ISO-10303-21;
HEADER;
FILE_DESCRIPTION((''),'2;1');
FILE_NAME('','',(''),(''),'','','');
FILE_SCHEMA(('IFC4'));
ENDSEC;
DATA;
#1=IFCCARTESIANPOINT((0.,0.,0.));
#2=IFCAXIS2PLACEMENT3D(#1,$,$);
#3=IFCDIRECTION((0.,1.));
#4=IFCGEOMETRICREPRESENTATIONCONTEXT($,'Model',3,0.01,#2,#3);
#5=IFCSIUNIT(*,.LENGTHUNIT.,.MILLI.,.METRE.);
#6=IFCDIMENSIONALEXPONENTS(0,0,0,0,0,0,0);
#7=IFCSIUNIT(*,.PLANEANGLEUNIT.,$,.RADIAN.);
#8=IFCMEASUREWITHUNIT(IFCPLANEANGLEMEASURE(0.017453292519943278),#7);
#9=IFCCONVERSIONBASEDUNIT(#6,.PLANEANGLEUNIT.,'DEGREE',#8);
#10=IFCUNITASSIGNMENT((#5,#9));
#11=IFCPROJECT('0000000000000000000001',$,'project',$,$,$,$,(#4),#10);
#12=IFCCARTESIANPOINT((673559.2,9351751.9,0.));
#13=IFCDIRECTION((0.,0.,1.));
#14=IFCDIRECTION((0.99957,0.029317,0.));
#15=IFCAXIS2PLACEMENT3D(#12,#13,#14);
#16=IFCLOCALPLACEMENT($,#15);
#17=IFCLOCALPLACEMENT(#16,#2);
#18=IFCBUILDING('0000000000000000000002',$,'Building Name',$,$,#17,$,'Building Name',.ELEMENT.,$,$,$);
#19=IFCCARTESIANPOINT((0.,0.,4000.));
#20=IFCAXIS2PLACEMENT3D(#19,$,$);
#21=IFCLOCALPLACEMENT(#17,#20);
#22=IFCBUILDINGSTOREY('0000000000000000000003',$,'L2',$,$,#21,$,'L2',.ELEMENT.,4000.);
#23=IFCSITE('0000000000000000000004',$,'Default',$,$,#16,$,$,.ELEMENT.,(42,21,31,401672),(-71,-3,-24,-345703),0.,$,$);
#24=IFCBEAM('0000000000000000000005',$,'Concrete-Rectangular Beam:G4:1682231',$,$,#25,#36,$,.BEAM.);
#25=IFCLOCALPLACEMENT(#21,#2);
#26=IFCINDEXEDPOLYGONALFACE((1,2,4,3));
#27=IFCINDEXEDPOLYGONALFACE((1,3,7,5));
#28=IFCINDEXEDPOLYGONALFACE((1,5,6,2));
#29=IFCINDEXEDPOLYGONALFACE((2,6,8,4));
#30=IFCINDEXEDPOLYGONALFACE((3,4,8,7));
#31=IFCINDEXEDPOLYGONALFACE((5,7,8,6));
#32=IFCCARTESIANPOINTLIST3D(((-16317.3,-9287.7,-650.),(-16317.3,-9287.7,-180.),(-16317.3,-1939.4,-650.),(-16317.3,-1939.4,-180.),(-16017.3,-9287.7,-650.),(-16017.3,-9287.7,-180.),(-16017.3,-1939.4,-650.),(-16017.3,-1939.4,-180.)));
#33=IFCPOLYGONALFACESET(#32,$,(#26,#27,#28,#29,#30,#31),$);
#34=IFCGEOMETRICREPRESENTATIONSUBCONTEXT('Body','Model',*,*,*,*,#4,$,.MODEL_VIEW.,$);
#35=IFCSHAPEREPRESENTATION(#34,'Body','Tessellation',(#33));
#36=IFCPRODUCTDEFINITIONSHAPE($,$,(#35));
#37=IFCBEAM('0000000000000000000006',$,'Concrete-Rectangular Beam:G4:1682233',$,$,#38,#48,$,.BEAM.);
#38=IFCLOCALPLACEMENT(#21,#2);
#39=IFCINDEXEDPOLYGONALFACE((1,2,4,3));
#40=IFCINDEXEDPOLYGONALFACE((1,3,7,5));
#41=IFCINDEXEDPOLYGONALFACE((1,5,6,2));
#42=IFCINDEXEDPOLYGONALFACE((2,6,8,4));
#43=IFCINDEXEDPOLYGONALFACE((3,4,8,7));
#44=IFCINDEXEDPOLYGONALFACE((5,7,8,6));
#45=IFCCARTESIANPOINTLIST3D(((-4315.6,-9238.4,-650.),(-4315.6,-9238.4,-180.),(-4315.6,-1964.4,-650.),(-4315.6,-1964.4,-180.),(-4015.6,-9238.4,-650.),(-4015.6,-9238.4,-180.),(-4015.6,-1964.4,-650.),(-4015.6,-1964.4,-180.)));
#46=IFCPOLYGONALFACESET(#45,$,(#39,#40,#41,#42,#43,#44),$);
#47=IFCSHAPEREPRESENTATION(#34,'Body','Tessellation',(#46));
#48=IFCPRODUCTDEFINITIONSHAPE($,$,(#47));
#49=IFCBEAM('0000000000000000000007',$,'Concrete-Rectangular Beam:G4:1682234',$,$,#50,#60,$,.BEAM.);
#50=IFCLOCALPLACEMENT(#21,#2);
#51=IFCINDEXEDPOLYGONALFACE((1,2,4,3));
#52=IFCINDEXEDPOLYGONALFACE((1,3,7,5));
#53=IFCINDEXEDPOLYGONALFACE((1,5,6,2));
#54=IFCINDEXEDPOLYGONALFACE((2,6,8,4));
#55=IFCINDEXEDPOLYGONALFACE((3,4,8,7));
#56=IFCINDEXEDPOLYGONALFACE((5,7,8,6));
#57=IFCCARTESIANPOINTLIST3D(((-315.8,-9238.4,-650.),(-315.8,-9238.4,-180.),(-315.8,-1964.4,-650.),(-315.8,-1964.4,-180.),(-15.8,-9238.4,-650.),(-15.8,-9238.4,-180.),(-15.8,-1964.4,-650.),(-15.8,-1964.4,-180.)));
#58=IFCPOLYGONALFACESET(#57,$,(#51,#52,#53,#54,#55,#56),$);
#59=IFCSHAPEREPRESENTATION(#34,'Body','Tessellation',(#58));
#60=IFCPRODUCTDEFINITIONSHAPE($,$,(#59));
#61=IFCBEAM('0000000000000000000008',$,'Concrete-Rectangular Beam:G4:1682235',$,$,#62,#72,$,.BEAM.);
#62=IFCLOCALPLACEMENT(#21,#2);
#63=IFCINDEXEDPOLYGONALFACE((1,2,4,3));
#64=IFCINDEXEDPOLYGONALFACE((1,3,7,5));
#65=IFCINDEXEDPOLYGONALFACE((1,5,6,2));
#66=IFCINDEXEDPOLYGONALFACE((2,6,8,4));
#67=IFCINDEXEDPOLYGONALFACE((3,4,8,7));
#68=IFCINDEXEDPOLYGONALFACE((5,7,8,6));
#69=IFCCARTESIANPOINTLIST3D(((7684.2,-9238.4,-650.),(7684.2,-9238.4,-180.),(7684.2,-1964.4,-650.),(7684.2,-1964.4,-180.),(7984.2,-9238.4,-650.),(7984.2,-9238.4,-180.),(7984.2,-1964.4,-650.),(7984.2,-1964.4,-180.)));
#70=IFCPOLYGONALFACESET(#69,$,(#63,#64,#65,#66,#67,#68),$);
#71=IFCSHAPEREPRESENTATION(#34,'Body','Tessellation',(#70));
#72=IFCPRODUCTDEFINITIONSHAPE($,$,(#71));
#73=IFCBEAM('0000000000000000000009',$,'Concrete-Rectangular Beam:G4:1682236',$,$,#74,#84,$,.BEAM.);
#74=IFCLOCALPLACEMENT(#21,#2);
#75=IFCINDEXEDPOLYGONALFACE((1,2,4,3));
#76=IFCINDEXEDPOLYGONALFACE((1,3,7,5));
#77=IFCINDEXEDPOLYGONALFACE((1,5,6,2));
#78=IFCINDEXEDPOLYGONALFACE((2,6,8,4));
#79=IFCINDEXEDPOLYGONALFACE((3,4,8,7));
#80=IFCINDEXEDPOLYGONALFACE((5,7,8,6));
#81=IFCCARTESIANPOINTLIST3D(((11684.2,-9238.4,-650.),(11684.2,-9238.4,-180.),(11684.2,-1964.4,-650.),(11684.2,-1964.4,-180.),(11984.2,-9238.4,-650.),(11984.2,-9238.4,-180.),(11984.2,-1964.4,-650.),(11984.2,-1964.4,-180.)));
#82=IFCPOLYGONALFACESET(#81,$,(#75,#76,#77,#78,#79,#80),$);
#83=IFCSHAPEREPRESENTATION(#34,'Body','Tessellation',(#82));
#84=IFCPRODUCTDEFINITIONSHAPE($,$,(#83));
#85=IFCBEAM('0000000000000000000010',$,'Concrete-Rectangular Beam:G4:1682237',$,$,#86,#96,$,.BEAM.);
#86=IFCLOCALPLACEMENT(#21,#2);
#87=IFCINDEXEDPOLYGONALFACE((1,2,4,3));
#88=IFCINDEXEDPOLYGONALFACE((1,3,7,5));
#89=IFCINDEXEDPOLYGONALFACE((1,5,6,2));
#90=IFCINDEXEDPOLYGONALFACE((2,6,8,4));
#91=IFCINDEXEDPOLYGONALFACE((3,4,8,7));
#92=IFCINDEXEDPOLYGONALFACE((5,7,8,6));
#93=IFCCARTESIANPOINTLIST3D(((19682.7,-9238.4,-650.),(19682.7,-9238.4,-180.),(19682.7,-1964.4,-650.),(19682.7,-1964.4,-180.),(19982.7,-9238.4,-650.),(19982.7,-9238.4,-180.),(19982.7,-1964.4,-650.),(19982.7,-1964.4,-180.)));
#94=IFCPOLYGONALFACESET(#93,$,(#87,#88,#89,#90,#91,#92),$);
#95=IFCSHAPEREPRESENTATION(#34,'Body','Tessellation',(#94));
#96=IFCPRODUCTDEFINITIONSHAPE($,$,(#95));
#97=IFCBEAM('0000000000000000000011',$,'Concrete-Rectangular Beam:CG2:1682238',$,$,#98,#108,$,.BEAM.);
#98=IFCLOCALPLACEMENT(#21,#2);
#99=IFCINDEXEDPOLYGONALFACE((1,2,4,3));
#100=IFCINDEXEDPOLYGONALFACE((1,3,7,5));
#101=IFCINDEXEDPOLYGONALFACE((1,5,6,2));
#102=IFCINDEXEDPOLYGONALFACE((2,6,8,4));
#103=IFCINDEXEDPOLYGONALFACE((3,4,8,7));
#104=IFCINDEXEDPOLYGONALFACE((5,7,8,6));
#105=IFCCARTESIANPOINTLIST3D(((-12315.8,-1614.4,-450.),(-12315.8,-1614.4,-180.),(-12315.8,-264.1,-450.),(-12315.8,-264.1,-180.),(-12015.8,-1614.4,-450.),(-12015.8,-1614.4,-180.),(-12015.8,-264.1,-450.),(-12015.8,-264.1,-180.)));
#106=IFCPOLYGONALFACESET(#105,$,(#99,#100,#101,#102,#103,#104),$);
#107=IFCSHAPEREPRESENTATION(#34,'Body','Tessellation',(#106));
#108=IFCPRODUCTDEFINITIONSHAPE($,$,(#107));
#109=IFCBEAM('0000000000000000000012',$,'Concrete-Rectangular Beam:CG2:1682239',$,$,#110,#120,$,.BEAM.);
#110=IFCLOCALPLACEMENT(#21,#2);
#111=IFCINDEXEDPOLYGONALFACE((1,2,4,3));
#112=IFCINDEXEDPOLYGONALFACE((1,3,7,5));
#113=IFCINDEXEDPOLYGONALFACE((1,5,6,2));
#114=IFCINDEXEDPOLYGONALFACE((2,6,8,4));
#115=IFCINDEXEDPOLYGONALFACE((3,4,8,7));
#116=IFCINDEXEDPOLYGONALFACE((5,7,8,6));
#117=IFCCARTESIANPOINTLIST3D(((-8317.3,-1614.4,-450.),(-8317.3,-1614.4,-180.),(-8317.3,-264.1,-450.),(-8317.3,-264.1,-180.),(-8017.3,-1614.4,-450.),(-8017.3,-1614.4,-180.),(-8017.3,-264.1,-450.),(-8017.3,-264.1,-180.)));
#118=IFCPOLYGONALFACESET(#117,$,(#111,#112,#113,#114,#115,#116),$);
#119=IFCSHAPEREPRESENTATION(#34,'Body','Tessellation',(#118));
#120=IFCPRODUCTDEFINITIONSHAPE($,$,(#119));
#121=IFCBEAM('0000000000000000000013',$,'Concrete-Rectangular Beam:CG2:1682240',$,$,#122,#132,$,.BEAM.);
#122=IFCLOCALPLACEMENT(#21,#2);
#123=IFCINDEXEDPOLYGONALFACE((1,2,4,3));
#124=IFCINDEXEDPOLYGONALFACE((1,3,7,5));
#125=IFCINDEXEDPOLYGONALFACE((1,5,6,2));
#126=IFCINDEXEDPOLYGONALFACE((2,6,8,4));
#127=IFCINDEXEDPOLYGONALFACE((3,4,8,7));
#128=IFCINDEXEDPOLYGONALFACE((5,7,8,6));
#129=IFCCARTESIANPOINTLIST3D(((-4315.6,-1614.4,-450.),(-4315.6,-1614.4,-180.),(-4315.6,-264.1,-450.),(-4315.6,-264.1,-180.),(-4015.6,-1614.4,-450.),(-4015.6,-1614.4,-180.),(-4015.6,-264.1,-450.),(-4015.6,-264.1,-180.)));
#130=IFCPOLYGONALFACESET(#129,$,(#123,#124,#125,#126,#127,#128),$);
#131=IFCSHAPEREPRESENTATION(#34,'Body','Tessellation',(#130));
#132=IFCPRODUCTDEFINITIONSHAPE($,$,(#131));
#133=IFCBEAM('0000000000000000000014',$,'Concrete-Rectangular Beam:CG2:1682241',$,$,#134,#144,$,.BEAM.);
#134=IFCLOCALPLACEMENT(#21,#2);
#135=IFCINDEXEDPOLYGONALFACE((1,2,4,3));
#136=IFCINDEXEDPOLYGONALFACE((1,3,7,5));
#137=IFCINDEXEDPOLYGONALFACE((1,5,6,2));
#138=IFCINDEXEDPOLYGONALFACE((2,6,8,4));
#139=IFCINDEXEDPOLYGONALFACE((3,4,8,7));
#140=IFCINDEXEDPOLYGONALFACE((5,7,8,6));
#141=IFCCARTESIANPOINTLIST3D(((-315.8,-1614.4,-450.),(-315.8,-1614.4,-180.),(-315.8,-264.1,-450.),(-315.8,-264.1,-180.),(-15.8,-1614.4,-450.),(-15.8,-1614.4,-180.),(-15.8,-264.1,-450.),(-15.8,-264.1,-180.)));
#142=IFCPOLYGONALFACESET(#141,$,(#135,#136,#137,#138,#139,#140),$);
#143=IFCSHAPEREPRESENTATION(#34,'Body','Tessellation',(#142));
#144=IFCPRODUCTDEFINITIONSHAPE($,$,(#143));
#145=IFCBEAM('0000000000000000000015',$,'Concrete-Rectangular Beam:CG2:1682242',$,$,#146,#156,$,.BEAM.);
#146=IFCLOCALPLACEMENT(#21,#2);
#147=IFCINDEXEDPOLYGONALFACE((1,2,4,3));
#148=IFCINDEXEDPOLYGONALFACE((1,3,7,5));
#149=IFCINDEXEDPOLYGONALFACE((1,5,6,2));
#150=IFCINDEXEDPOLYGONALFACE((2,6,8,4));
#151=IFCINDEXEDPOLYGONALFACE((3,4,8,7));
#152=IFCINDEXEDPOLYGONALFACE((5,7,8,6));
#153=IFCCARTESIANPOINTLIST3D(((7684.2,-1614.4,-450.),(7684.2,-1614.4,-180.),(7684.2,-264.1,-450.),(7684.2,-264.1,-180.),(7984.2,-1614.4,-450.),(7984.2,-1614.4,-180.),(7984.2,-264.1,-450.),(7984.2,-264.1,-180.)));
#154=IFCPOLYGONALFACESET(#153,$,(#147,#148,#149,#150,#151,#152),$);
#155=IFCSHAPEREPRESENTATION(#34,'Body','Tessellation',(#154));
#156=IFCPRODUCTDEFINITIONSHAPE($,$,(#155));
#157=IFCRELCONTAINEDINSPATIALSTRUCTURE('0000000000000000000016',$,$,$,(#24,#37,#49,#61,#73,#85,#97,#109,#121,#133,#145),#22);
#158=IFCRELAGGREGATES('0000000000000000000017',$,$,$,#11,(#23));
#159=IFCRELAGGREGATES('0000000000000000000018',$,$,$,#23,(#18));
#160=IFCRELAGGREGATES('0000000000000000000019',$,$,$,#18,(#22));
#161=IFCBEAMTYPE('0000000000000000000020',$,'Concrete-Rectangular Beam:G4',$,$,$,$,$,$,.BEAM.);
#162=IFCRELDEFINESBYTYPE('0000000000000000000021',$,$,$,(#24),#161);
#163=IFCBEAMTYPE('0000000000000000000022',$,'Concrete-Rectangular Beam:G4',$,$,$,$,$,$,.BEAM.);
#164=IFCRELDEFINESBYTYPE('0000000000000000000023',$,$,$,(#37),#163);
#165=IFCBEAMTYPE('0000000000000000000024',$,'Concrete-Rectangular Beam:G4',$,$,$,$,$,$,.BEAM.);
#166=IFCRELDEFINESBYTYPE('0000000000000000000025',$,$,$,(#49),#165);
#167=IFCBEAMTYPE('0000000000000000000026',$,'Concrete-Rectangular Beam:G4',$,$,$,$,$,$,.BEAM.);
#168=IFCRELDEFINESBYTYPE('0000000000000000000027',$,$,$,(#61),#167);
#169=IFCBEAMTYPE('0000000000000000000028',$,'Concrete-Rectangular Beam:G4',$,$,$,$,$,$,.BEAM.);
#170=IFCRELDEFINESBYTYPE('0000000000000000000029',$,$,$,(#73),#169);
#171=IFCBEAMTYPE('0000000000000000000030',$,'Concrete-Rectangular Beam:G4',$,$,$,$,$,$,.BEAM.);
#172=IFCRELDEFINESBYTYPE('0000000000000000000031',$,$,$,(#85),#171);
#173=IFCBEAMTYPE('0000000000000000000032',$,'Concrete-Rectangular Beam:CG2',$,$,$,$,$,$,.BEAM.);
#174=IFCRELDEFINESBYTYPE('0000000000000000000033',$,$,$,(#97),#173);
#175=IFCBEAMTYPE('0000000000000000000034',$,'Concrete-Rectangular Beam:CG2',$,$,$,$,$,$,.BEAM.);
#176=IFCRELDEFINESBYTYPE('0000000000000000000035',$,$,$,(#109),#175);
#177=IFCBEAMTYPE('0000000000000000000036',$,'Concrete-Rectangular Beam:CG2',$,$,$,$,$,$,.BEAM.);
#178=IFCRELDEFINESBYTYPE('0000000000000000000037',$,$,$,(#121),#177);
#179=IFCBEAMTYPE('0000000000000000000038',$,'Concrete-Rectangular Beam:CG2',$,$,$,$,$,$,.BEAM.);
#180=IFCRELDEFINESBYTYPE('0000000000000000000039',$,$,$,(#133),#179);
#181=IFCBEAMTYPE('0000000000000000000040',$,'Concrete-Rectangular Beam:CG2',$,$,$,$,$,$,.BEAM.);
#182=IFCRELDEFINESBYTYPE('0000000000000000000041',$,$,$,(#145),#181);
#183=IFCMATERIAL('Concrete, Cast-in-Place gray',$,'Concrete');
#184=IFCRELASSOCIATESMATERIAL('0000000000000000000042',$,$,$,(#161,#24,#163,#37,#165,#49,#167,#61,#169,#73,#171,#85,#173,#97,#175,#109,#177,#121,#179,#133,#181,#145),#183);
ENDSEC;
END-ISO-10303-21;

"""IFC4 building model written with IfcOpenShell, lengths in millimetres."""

from ifc_helpers import new_model, entity, si_unit, converted_unit, direction, frame, origin, place, context, subcontext, project, spatial, indexed_curve, outline, extrude, source, transform, mapped, material, type_object, type_shapes, element, save


model = new_model("IFC4")

# Units and contexts
model_context = context("Model", 3, precision=0.01, world=origin(), true_north=direction((0.0, 1.0)))
body_context = subcontext(model_context, "Body", "Model", "MODEL_VIEW")
ifc_project = project(units=[si_unit("LENGTHUNIT", "METRE", prefix="MILLI"), converted_unit("PLANEANGLEUNIT", "DEGREE", entity("IfcPlaneAngleMeasure", 0.017453292519943278), si_unit("PLANEANGLEUNIT", "RADIAN"), dimensions=[0, 0, 0, 0, 0, 0, 0])], contexts=[model_context])

# Site, building, storey
site_placement = place(None, frame((673559.2, 9351751.9, 0.0), z_axis=(0.0, 0.0, 1.0), x_axis=(0.99957, 0.029317, 0.0)))
site = spatial("IfcSite", under=ifc_project, at=site_placement, Name="Default", CompositionType="ELEMENT", RefLatitude=(42, 21, 31, 401672), RefLongitude=(-71, -3, -24, -345703), RefElevation=0.0)
building_placement = place(site_placement, origin())
building = spatial("IfcBuilding", under=site, at=building_placement, Name="Building Name", LongName="Building Name", CompositionType="ELEMENT")
storey_placement = place(building_placement, frame((0.0, 0.0, 4000.0)))
storey = spatial("IfcBuildingStorey", under=building, at=storey_placement, Name="L2", LongName="L2", CompositionType="ELEMENT", Elevation=4000.0)

# Beams
ifc_material = material(Name="Concrete, Cast-in-Place gray", Category="Concrete")
beam_type_1 = type_object("IfcBeamType", Name="Concrete-Rectangular Beam:G4", PredefinedType="BEAM", material=ifc_material)
shared_shape_1 = source(origin(), body_context, "Body", "SweptSolid", [
    extrude(outline(indexed_curve([(-150.0, -235.0), (150.0, -235.0), (150.0, 235.0), (-150.0, 235.0), (-150.0, -235.0)], self_intersect=False)), frame((-16167.3, -9287.7, 3585.0), z_axis=(0.0, 1.0, 0.0), x_axis=(-1.0, 0.0, 0.0)), (0.0, 0.0, 1.0), 7348.3),
])
type_shapes(beam_type_1, [shared_shape_1])
beam_1_placement = place(storey_placement, frame((0.0, 0.0, -4000.0)))
element("IfcBeam", 1, at=beam_1_placement, inside=storey, type_object=beam_type_1, material=ifc_material, Name="Concrete-Rectangular Beam:G4:1682231", PredefinedType="BEAM", context=body_context, shape_type="MappedRepresentation", body=[
    mapped(shared_shape_1, transform((0.0, 0.0, 0.0), scale=1.0)),
])
beam_type_2 = type_object("IfcBeamType", Name="Concrete-Rectangular Beam:G4", PredefinedType="BEAM", material=ifc_material)
shared_shape_2 = source(origin(), body_context, "Body", "SweptSolid", [
    extrude(outline(indexed_curve([(-150.0, -235.0), (150.0, -235.0), (150.0, 235.0), (-150.0, 235.0), (-150.0, -235.0)], self_intersect=False)), frame((-4165.6, -9238.4, 3585.0), z_axis=(0.0, 1.0, 0.0), x_axis=(-1.0, 0.0, 0.0)), (0.0, 0.0, 1.0), 7273.9),
])
type_shapes(beam_type_2, [shared_shape_2])
beam_2_placement = place(storey_placement, frame((0.0, 0.0, -4000.0)))
element("IfcBeam", 2, at=beam_2_placement, inside=storey, type_object=beam_type_2, material=ifc_material, Name="Concrete-Rectangular Beam:G4:1682233", PredefinedType="BEAM", context=body_context, shape_type="MappedRepresentation", body=[
    mapped(shared_shape_2, transform((0.0, 0.0, 0.0), scale=1.0)),
])
beam_type_3 = type_object("IfcBeamType", Name="Concrete-Rectangular Beam:G4", PredefinedType="BEAM", material=ifc_material)
shared_shape_3 = source(origin(), body_context, "Body", "SweptSolid", [
    extrude(outline(indexed_curve([(-150.0, -235.0), (150.0, -235.0), (150.0, 235.0), (-150.0, 235.0), (-150.0, -235.0)], self_intersect=False)), frame((-165.8, -9238.4, 3585.0), z_axis=(0.0, 1.0, 0.0), x_axis=(-1.0, 0.0, 0.0)), (0.0, 0.0, 1.0), 7273.9),
])
type_shapes(beam_type_3, [shared_shape_3])
beam_3_placement = place(storey_placement, frame((0.0, 0.0, -4000.0)))
element("IfcBeam", 3, at=beam_3_placement, inside=storey, type_object=beam_type_3, material=ifc_material, Name="Concrete-Rectangular Beam:G4:1682234", PredefinedType="BEAM", context=body_context, shape_type="MappedRepresentation", body=[
    mapped(shared_shape_3, transform((0.0, 0.0, 0.0), scale=1.0)),
])
beam_type_4 = type_object("IfcBeamType", Name="Concrete-Rectangular Beam:G4", PredefinedType="BEAM", material=ifc_material)
shared_shape_4 = source(origin(), body_context, "Body", "SweptSolid", [
    extrude(outline(indexed_curve([(-150.0, -235.0), (150.0, -235.0), (150.0, 235.0), (-150.0, 235.0), (-150.0, -235.0)], self_intersect=False)), frame((7834.2, -9238.4, 3585.0), z_axis=(0.0, 1.0, 0.0), x_axis=(-1.0, 0.0, 0.0)), (0.0, 0.0, 1.0), 7273.9),
])
type_shapes(beam_type_4, [shared_shape_4])
beam_4_placement = place(storey_placement, frame((0.0, 0.0, -4000.0)))
element("IfcBeam", 4, at=beam_4_placement, inside=storey, type_object=beam_type_4, material=ifc_material, Name="Concrete-Rectangular Beam:G4:1682235", PredefinedType="BEAM", context=body_context, shape_type="MappedRepresentation", body=[
    mapped(shared_shape_4, transform((0.0, 0.0, 0.0), scale=1.0)),
])
beam_type_5 = type_object("IfcBeamType", Name="Concrete-Rectangular Beam:G4", PredefinedType="BEAM", material=ifc_material)
shared_shape_5 = source(origin(), body_context, "Body", "SweptSolid", [
    extrude(outline(indexed_curve([(-150.0, -235.0), (150.0, -235.0), (150.0, 235.0), (-150.0, 235.0), (-150.0, -235.0)], self_intersect=False)), frame((11834.2, -9238.4, 3585.0), z_axis=(0.0, 1.0, 0.0), x_axis=(-1.0, 0.0, 0.0)), (0.0, 0.0, 1.0), 7273.9),
])
type_shapes(beam_type_5, [shared_shape_5])
beam_5_placement = place(storey_placement, frame((0.0, 0.0, -4000.0)))
element("IfcBeam", 5, at=beam_5_placement, inside=storey, type_object=beam_type_5, material=ifc_material, Name="Concrete-Rectangular Beam:G4:1682236", PredefinedType="BEAM", context=body_context, shape_type="MappedRepresentation", body=[
    mapped(shared_shape_5, transform((0.0, 0.0, 0.0), scale=1.0)),
])
beam_type_6 = type_object("IfcBeamType", Name="Concrete-Rectangular Beam:G4", PredefinedType="BEAM", material=ifc_material)
shared_shape_6 = source(origin(), body_context, "Body", "SweptSolid", [
    extrude(outline(indexed_curve([(-150.0, -235.0), (150.0, -235.0), (150.0, 235.0), (-150.0, 235.0), (-150.0, -235.0)], self_intersect=False)), frame((19832.7, -9238.4, 3585.0), z_axis=(0.0, 1.0, 0.0), x_axis=(-1.0, 0.0, 0.0)), (0.0, 0.0, 1.0), 7273.9),
])
type_shapes(beam_type_6, [shared_shape_6])
beam_6_placement = place(storey_placement, frame((0.0, 0.0, -4000.0)))
element("IfcBeam", 6, at=beam_6_placement, inside=storey, type_object=beam_type_6, material=ifc_material, Name="Concrete-Rectangular Beam:G4:1682237", PredefinedType="BEAM", context=body_context, shape_type="MappedRepresentation", body=[
    mapped(shared_shape_6, transform((0.0, 0.0, 0.0), scale=1.0)),
])
beam_type_7 = type_object("IfcBeamType", Name="Concrete-Rectangular Beam:CG2", PredefinedType="BEAM", material=ifc_material)
shared_shape_7 = source(origin(), body_context, "Body", "SweptSolid", [
    extrude(outline(indexed_curve([(-150.0, -135.0), (150.0, -135.0), (150.0, 135.0), (-150.0, 135.0), (-150.0, -135.0)], self_intersect=False)), frame((-12165.8, -1614.4, 3685.0), z_axis=(0.0, 1.0, 0.0), x_axis=(-1.0, 0.0, 0.0)), (0.0, 0.0, 1.0), 1350.4),
])
type_shapes(beam_type_7, [shared_shape_7])
beam_7_placement = place(storey_placement, frame((0.0, 0.0, -4000.0)))
element("IfcBeam", 7, at=beam_7_placement, inside=storey, type_object=beam_type_7, material=ifc_material, Name="Concrete-Rectangular Beam:CG2:1682238", PredefinedType="BEAM", context=body_context, shape_type="MappedRepresentation", body=[
    mapped(shared_shape_7, transform((0.0, 0.0, 0.0), scale=1.0)),
])
beam_type_8 = type_object("IfcBeamType", Name="Concrete-Rectangular Beam:CG2", PredefinedType="BEAM", material=ifc_material)
shared_shape_8 = source(origin(), body_context, "Body", "SweptSolid", [
    extrude(outline(indexed_curve([(-150.0, -135.0), (150.0, -135.0), (150.0, 135.0), (-150.0, 135.0), (-150.0, -135.0)], self_intersect=False)), frame((-8167.3, -1614.4, 3685.0), z_axis=(0.0, 1.0, 0.0), x_axis=(-1.0, 0.0, 0.0)), (0.0, 0.0, 1.0), 1350.4),
])
type_shapes(beam_type_8, [shared_shape_8])
beam_8_placement = place(storey_placement, frame((0.0, 0.0, -4000.0)))
element("IfcBeam", 8, at=beam_8_placement, inside=storey, type_object=beam_type_8, material=ifc_material, Name="Concrete-Rectangular Beam:CG2:1682239", PredefinedType="BEAM", context=body_context, shape_type="MappedRepresentation", body=[
    mapped(shared_shape_8, transform((0.0, 0.0, 0.0), scale=1.0)),
])
beam_type_9 = type_object("IfcBeamType", Name="Concrete-Rectangular Beam:CG2", PredefinedType="BEAM", material=ifc_material)
shared_shape_9 = source(origin(), body_context, "Body", "SweptSolid", [
    extrude(outline(indexed_curve([(-150.0, -135.0), (150.0, -135.0), (150.0, 135.0), (-150.0, 135.0), (-150.0, -135.0)], self_intersect=False)), frame((-4165.6, -1614.4, 3685.0), z_axis=(0.0, 1.0, 0.0), x_axis=(-1.0, 0.0, 0.0)), (0.0, 0.0, 1.0), 1350.4),
])
type_shapes(beam_type_9, [shared_shape_9])
beam_9_placement = place(storey_placement, frame((0.0, 0.0, -4000.0)))
element("IfcBeam", 9, at=beam_9_placement, inside=storey, type_object=beam_type_9, material=ifc_material, Name="Concrete-Rectangular Beam:CG2:1682240", PredefinedType="BEAM", context=body_context, shape_type="MappedRepresentation", body=[
    mapped(shared_shape_9, transform((0.0, 0.0, 0.0), scale=1.0)),
])
beam_type_10 = type_object("IfcBeamType", Name="Concrete-Rectangular Beam:CG2", PredefinedType="BEAM", material=ifc_material)
shared_shape_10 = source(origin(), body_context, "Body", "SweptSolid", [
    extrude(outline(indexed_curve([(-150.0, -135.0), (150.0, -135.0), (150.0, 135.0), (-150.0, 135.0), (-150.0, -135.0)], self_intersect=False)), frame((-165.8, -1614.4, 3685.0), z_axis=(0.0, 1.0, 0.0), x_axis=(-1.0, 0.0, 0.0)), (0.0, 0.0, 1.0), 1350.4),
])
type_shapes(beam_type_10, [shared_shape_10])
beam_10_placement = place(storey_placement, frame((0.0, 0.0, -4000.0)))
element("IfcBeam", 10, at=beam_10_placement, inside=storey, type_object=beam_type_10, material=ifc_material, Name="Concrete-Rectangular Beam:CG2:1682241", PredefinedType="BEAM", context=body_context, shape_type="MappedRepresentation", body=[
    mapped(shared_shape_10, transform((0.0, 0.0, 0.0), scale=1.0)),
])
beam_type_11 = type_object("IfcBeamType", Name="Concrete-Rectangular Beam:CG2", PredefinedType="BEAM", material=ifc_material)
shared_shape_11 = source(origin(), body_context, "Body", "SweptSolid", [
    extrude(outline(indexed_curve([(-150.0, -135.0), (150.0, -135.0), (150.0, 135.0), (-150.0, 135.0), (-150.0, -135.0)], self_intersect=False)), frame((7834.2, -1614.4, 3685.0), z_axis=(0.0, 1.0, 0.0), x_axis=(-1.0, 0.0, 0.0)), (0.0, 0.0, 1.0), 1350.4),
])
type_shapes(beam_type_11, [shared_shape_11])
beam_11_placement = place(storey_placement, frame((0.0, 0.0, -4000.0)))
element("IfcBeam", 11, at=beam_11_placement, inside=storey, type_object=beam_type_11, material=ifc_material, Name="Concrete-Rectangular Beam:CG2:1682242", PredefinedType="BEAM", context=body_context, shape_type="MappedRepresentation", body=[
    mapped(shared_shape_11, transform((0.0, 0.0, 0.0), scale=1.0)),
])

save(model, "model.ifc")
